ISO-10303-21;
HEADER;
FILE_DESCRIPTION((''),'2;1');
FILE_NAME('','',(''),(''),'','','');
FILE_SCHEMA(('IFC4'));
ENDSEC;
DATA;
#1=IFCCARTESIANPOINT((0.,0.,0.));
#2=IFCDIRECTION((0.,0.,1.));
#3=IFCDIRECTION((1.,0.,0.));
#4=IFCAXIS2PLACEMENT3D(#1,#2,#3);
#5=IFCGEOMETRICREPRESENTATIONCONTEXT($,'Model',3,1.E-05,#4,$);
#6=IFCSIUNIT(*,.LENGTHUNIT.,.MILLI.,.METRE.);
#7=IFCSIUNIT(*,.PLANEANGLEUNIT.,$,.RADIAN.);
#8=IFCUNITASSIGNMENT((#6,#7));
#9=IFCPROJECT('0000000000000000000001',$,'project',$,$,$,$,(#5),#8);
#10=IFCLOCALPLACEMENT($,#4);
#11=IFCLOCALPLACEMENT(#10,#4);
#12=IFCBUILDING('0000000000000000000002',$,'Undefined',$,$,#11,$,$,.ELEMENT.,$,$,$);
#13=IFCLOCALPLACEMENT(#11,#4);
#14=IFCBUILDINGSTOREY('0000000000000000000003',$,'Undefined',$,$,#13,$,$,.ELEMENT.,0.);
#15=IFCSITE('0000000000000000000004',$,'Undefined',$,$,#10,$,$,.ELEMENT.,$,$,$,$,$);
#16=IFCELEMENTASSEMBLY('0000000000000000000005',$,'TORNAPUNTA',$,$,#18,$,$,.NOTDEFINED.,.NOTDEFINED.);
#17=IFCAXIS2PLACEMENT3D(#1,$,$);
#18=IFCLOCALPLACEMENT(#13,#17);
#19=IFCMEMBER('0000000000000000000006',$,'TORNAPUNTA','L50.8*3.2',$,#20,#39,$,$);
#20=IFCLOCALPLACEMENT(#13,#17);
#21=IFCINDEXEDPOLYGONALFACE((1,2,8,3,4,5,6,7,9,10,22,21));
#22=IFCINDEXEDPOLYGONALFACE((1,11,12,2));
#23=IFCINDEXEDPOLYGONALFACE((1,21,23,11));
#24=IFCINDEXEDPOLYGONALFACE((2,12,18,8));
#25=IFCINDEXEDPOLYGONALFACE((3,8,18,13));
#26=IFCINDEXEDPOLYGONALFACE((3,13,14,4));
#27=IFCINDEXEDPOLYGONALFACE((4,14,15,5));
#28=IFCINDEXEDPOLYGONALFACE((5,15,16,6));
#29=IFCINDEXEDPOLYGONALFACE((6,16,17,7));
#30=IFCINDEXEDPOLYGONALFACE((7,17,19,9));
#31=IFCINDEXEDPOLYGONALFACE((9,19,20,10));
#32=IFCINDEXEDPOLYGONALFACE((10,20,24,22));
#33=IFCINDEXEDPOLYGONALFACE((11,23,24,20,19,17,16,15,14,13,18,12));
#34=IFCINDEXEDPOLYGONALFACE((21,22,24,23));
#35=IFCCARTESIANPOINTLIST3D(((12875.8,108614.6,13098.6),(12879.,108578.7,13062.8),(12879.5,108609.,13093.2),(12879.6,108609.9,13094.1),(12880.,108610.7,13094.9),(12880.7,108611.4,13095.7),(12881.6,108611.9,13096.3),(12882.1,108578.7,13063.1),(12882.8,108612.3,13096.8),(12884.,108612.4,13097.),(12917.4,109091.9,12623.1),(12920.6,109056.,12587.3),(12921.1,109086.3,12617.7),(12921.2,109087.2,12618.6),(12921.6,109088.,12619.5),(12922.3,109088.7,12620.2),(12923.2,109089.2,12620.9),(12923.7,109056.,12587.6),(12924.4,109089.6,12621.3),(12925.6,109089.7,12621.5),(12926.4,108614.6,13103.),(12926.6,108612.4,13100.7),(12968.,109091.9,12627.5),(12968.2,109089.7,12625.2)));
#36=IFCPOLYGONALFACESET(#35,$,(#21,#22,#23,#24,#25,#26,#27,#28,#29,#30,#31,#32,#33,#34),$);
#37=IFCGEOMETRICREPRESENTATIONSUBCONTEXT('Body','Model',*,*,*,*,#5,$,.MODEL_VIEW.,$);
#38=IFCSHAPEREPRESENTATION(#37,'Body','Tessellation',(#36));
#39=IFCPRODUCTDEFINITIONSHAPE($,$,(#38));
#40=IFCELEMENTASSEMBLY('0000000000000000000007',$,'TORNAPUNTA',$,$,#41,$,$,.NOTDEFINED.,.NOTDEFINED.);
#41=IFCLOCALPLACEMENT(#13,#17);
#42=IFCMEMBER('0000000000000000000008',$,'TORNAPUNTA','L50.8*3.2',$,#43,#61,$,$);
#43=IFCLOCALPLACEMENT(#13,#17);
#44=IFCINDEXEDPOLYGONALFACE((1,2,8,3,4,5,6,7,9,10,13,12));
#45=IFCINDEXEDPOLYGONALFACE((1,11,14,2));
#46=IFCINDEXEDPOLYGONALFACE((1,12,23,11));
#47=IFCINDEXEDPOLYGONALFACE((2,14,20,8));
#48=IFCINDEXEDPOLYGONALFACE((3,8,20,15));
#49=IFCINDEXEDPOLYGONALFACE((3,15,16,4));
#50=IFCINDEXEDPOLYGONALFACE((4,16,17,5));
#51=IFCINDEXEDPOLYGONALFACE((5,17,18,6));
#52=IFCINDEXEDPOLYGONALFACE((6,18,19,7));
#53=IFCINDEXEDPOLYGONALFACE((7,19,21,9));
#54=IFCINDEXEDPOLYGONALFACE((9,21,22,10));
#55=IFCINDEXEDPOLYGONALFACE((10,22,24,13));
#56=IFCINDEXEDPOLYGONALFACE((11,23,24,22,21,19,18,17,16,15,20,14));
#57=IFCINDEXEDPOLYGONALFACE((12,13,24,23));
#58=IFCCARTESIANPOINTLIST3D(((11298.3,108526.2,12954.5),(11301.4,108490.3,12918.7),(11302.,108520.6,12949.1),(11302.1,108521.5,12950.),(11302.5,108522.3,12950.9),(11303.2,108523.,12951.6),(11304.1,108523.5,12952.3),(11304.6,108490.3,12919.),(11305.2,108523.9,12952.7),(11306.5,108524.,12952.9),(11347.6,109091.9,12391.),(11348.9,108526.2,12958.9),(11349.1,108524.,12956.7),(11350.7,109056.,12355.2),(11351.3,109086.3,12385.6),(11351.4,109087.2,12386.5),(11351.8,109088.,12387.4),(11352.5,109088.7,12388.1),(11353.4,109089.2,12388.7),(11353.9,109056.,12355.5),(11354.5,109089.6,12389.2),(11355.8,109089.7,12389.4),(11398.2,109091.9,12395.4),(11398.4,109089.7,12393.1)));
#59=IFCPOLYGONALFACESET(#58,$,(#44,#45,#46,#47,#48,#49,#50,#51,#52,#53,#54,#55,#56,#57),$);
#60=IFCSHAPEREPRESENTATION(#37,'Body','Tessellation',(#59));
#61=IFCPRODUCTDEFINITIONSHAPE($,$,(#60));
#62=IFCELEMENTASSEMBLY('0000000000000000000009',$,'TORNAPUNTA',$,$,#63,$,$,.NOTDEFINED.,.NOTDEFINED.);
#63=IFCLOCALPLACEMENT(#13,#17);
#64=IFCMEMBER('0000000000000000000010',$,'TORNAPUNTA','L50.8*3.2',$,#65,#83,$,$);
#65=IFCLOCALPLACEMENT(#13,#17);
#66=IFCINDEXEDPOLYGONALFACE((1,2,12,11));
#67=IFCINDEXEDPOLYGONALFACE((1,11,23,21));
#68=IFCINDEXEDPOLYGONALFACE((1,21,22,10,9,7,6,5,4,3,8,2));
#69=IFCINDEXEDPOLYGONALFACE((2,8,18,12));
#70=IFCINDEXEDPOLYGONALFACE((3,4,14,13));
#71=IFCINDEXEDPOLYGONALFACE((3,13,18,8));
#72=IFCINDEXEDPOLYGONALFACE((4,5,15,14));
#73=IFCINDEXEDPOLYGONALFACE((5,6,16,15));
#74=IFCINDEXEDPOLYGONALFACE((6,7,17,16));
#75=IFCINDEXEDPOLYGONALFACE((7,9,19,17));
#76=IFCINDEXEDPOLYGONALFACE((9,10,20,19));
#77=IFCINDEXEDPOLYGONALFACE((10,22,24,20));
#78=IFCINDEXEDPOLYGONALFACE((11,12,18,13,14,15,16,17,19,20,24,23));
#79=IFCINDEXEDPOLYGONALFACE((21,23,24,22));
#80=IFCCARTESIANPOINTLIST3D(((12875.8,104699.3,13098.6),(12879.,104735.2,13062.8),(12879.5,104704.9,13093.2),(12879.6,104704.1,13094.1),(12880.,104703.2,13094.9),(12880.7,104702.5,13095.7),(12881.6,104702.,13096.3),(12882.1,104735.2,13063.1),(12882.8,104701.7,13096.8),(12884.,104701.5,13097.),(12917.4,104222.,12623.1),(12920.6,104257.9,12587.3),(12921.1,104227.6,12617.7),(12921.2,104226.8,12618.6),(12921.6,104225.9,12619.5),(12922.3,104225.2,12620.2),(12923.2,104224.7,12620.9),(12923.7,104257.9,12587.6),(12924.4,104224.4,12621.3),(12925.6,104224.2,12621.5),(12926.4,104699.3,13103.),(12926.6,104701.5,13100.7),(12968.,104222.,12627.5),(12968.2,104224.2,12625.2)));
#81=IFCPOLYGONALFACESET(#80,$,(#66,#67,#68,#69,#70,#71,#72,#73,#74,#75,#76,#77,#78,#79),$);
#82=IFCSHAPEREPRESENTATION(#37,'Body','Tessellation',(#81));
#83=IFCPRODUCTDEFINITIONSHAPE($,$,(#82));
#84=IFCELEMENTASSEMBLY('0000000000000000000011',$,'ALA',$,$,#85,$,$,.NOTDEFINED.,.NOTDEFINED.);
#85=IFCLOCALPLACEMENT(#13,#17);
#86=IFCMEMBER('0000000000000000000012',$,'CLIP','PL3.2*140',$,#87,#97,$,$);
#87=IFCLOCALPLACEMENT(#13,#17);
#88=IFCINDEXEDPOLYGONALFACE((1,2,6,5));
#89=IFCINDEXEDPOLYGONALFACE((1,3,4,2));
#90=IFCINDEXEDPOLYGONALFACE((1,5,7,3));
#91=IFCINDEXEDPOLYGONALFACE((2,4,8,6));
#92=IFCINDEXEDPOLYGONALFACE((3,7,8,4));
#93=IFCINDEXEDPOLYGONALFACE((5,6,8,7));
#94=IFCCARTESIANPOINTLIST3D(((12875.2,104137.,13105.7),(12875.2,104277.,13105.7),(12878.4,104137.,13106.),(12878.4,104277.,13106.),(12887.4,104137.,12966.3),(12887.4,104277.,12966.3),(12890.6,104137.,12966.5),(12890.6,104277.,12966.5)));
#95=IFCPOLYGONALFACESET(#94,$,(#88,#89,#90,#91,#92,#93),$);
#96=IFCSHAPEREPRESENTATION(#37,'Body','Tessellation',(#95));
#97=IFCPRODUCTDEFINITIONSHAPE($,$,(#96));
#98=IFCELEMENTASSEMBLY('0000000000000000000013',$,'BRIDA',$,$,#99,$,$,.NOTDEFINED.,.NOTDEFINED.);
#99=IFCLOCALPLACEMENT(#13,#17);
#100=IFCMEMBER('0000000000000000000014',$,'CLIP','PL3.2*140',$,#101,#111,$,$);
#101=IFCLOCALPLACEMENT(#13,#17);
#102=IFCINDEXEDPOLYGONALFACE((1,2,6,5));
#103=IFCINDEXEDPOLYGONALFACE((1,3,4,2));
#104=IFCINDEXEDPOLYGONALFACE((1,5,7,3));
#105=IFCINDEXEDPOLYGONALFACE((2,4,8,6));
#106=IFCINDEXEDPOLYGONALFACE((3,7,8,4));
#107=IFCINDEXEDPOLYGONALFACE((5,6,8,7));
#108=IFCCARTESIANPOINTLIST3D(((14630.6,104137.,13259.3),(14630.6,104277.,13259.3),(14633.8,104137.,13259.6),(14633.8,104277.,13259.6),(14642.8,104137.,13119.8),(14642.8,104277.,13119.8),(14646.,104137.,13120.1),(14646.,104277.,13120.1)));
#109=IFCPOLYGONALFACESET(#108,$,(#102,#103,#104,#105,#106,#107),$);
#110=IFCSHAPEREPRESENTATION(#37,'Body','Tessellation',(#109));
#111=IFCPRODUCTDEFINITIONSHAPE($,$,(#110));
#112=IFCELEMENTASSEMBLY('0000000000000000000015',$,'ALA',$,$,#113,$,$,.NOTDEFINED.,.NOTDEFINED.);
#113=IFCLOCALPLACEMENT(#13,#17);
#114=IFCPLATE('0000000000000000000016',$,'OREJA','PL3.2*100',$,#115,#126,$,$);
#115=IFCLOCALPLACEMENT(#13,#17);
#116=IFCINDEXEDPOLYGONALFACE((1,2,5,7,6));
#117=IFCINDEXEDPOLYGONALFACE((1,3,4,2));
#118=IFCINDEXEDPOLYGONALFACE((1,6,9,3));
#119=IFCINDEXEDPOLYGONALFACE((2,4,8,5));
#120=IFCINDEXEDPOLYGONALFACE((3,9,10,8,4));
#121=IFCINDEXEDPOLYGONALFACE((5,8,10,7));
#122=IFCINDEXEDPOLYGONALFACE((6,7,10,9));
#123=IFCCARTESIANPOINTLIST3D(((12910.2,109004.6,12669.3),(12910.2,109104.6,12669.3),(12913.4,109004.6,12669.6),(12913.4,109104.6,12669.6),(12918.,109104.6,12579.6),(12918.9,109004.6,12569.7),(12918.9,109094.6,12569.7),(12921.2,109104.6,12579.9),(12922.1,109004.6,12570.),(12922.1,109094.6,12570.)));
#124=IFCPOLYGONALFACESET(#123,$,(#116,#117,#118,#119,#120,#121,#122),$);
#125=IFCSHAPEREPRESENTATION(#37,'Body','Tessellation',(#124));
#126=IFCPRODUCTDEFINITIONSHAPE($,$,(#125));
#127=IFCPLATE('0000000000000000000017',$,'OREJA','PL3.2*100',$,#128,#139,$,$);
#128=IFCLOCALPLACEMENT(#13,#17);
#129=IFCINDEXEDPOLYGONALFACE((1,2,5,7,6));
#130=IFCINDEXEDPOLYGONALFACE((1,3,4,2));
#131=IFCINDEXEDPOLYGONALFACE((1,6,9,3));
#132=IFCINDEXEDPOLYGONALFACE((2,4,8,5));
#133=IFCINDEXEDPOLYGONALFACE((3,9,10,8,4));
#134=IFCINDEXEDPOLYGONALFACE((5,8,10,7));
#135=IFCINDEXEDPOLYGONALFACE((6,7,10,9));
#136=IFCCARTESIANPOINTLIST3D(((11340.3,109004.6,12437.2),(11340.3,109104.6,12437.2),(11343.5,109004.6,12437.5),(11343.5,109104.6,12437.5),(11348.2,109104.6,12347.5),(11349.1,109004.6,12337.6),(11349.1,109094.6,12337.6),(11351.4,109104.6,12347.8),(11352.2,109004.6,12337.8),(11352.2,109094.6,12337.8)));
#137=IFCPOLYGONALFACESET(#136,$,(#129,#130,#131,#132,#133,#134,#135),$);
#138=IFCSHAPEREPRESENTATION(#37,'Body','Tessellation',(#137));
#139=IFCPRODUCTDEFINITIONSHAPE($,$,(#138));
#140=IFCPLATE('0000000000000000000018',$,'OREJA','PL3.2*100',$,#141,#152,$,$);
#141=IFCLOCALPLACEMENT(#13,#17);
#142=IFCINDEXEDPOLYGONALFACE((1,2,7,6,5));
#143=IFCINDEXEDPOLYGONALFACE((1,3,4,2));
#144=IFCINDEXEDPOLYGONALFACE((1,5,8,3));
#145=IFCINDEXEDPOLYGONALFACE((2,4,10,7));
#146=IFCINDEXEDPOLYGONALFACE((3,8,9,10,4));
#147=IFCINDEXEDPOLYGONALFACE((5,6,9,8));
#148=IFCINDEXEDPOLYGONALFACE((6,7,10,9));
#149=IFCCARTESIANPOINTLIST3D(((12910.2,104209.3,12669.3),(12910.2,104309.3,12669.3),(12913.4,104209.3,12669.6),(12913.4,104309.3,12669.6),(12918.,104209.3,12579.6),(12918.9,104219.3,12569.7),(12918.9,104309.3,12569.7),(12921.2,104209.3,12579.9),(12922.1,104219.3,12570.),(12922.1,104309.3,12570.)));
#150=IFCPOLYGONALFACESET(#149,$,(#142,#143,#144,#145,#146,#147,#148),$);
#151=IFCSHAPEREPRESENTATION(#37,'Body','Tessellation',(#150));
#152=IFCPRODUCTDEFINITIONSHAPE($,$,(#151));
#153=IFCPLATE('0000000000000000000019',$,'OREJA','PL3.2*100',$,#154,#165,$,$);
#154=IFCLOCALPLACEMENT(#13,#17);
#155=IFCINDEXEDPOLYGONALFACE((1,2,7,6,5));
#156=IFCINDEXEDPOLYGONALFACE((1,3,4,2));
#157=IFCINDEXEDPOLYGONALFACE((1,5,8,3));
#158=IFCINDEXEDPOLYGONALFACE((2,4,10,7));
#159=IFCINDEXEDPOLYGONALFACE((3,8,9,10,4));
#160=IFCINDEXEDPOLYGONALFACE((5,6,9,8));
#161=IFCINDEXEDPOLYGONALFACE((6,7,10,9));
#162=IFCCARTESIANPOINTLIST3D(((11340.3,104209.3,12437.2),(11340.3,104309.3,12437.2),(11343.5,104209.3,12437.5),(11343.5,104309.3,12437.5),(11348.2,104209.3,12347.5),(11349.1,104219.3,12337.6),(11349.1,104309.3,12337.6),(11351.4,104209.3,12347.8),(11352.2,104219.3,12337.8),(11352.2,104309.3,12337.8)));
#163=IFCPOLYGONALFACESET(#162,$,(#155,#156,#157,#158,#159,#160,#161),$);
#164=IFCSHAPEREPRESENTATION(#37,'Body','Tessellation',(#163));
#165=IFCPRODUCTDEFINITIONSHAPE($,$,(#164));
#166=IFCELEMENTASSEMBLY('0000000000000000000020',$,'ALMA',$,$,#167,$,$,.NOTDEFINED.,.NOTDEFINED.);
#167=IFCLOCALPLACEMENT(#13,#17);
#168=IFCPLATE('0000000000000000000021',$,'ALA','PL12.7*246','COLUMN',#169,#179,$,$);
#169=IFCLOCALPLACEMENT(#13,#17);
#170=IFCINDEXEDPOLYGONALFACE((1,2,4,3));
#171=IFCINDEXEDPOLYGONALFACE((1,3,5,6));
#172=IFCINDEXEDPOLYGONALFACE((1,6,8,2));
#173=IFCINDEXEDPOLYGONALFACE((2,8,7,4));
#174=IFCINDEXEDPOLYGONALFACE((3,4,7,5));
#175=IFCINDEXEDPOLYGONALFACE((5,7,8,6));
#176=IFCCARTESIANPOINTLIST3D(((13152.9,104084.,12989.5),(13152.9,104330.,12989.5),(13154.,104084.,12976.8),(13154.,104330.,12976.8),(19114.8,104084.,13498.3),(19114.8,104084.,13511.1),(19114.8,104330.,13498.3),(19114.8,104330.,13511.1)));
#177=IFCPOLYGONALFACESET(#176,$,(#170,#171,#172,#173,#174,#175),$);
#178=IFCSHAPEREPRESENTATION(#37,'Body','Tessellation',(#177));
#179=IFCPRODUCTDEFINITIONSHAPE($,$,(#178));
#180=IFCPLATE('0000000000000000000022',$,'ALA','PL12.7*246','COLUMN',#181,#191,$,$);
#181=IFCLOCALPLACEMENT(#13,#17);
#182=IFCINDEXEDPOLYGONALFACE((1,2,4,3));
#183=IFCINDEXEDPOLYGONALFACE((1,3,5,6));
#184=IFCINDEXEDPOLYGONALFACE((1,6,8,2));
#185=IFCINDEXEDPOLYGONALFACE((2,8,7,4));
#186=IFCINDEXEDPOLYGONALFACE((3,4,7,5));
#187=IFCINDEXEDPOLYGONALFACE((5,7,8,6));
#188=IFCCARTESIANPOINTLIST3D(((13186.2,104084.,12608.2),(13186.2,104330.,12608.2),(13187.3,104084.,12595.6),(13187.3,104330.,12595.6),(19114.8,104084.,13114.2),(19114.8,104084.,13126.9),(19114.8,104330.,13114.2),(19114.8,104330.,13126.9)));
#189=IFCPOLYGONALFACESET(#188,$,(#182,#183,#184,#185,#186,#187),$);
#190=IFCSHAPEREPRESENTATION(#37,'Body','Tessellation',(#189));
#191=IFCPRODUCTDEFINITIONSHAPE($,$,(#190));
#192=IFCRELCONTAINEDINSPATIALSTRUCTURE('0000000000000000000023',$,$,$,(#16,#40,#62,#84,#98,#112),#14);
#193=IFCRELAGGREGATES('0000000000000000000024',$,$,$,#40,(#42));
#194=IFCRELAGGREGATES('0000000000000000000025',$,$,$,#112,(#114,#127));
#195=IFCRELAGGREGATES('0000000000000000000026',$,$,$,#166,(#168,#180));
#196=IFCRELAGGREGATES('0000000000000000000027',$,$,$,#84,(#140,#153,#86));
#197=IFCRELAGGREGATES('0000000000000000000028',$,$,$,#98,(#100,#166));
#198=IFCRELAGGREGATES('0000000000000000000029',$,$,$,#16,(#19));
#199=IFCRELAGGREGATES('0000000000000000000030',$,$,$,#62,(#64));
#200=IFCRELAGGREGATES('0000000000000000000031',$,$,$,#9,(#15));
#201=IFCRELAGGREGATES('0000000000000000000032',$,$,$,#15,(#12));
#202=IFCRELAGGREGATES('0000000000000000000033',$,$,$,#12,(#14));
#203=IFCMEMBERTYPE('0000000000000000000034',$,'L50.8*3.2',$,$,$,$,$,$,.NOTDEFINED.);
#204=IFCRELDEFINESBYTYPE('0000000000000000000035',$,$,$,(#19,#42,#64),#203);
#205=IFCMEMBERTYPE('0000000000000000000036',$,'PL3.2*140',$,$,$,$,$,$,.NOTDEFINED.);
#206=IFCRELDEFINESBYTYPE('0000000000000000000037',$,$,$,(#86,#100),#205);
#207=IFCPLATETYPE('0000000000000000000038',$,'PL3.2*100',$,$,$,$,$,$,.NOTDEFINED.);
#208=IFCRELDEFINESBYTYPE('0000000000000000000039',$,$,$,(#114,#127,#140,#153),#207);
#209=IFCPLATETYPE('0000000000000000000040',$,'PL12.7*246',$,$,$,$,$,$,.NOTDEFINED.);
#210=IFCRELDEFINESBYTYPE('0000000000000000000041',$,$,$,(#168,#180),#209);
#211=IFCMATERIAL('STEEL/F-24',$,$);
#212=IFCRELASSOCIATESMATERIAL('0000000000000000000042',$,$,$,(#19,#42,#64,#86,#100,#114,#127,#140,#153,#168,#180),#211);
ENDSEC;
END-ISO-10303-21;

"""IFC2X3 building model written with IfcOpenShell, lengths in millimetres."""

from ifc_helpers import new_model, si_unit, frame, origin_with_axes, origin_2d_with_axis, place, context, subcontext, project, spatial, polyline, rectangle, l_section, outline, extrude, clip, halfspace, material, type_object, element, aggregate, save


model = new_model("IFC2X3")

# Units and contexts
model_context = context("Model", 3, precision=1e-05, world=origin_with_axes())
body_context = subcontext(model_context, "Body", "Model", "MODEL_VIEW")
ifc_project = project(units=[si_unit("LENGTHUNIT", "METRE", prefix="MILLI"), si_unit("PLANEANGLEUNIT", "RADIAN")], contexts=[model_context])

# Site, building, storey
site_placement = place(None, origin_with_axes())
site = spatial("IfcSite", under=ifc_project, at=site_placement, Name="Undefined", CompositionType="ELEMENT")
building_placement = place(site_placement, origin_with_axes())
building = spatial("IfcBuilding", under=site, at=building_placement, Name="Undefined", CompositionType="ELEMENT")
storey_placement = place(building_placement, origin_with_axes())
storey = spatial("IfcBuildingStorey", under=building, at=storey_placement, Name="Undefined", CompositionType="ELEMENT", Elevation=0.0)

# Element assemblies, members
assembly_1_placement = place(storey_placement, origin_with_axes())
assembly_1 = element("IfcElementAssembly", 1, at=assembly_1_placement, inside=storey, Name="TORNAPUNTA", AssemblyPlace="NOTDEFINED", PredefinedType="NOTDEFINED")
ifc_material_1 = material(Name="STEEL/F-24")
member_type_1 = type_object("IfcMemberType", Name="L50.8*3.2", PredefinedType="NOTDEFINED")
member_1_placement = place(assembly_1_placement, frame((12944.3, 109074.0, 12607.4), z_axis=(0.061628, -0.707107, -0.704416), x_axis=(-0.061628, -0.707107, 0.704416)))
member_1 = element("IfcMember", 2, at=member_1_placement, type_object=member_type_1, material=ifc_material_1, Name="TORNAPUNTA", Description="L50.8*3.2", context=body_context, shape_type="SweptSolid", body=[
    extrude(l_section(Depth=50.8, Width=50.8, Thickness=3.2, FilletRadius=4.8, at=origin_2d_with_axis()), frame((675.0, 0.0, 0.0), z_axis=(-1.0, 0.0, 0.0), x_axis=(0.0, -1.0, 0.0)), (0.0, 0.0, 1.0), 675.0),
])
assembly_2_placement = place(storey_placement, origin_with_axes())
assembly_2 = element("IfcElementAssembly", 3, at=assembly_2_placement, inside=storey, Name="TORNAPUNTA", AssemblyPlace="NOTDEFINED", PredefinedType="NOTDEFINED")
member_2_placement = place(assembly_2_placement, frame((11374.5, 109074.0, 12375.3), z_axis=(0.061628, -0.707107, -0.704416), x_axis=(-0.061628, -0.707107, 0.704416)))
member_2 = element("IfcMember", 4, at=member_2_placement, type_object=member_type_1, material=ifc_material_1, Name="TORNAPUNTA", Description="L50.8*3.2", context=body_context, shape_type="SweptSolid", body=[
    extrude(l_section(Depth=50.8, Width=50.8, Thickness=3.2, FilletRadius=4.8, at=origin_2d_with_axis()), frame((800.0, 0.0, 0.0), z_axis=(-1.0, 0.0, 0.0), x_axis=(0.0, -1.0, 0.0)), (0.0, 0.0, 1.0), 800.0),
])
aggregate(assembly_2, [member_2])
assembly_3_placement = place(storey_placement, origin_with_axes())
assembly_3 = element("IfcElementAssembly", 5, at=assembly_3_placement, inside=storey, Name="TORNAPUNTA", AssemblyPlace="NOTDEFINED", PredefinedType="NOTDEFINED")
member_3_placement = place(assembly_3_placement, frame((12902.7, 104717.2, 13082.9), z_axis=(0.061628, 0.707107, -0.704416), x_axis=(0.061628, -0.707107, -0.704416)))
member_3 = element("IfcMember", 6, at=member_3_placement, type_object=member_type_1, material=ifc_material_1, Name="TORNAPUNTA", Description="L50.8*3.2", context=body_context, shape_type="SweptSolid", body=[
    extrude(l_section(Depth=50.8, Width=50.8, Thickness=3.2, FilletRadius=4.8, at=origin_2d_with_axis()), frame((675.0, 0.0, 0.0), z_axis=(-1.0, 0.0, 0.0), x_axis=(0.0, -1.0, 0.0)), (0.0, 0.0, 1.0), 675.0),
])
assembly_4_placement = place(storey_placement, origin_with_axes())
assembly_4 = element("IfcElementAssembly", 7, at=assembly_4_placement, inside=storey, Name="ALA", AssemblyPlace="NOTDEFINED", PredefinedType="NOTDEFINED")
member_type_2 = type_object("IfcMemberType", Name="PL3.2*140", PredefinedType="NOTDEFINED")
member_4_placement = place(assembly_4_placement, frame((12876.8, 104207.0, 13105.9), z_axis=(0.0, -1.0, 0.0), x_axis=(0.087155, 0.0, -0.996195)))
member_4 = element("IfcMember", 8, at=member_4_placement, type_object=member_type_2, material=ifc_material_1, Name="CLIP", Description="PL3.2*140", context=body_context, shape_type="SweptSolid", body=[
    extrude(rectangle(XDim=3.2, YDim=140.0, at=origin_2d_with_axis()), frame((140.0, 0.0, 0.0), z_axis=(-1.0, 0.0, 0.0), x_axis=(0.0, -1.0, 0.0)), (0.0, 0.0, 1.0), 140.0),
])
assembly_5_placement = place(storey_placement, origin_with_axes())
assembly_5 = element("IfcElementAssembly", 9, at=assembly_5_placement, inside=storey, Name="BRIDA", AssemblyPlace="NOTDEFINED", PredefinedType="NOTDEFINED")
member_5_placement = place(assembly_5_placement, frame((14632.2, 104207.0, 13259.5), z_axis=(0.0, -1.0, 0.0), x_axis=(0.087155, 0.0, -0.996195)))
member_5 = element("IfcMember", 10, at=member_5_placement, type_object=member_type_2, material=ifc_material_1, Name="CLIP", Description="PL3.2*140", context=body_context, shape_type="SweptSolid", body=[
    extrude(rectangle(XDim=3.2, YDim=140.0, at=origin_2d_with_axis()), frame((140.0, 0.0, 0.0), z_axis=(-1.0, 0.0, 0.0), x_axis=(0.0, -1.0, 0.0)), (0.0, 0.0, 1.0), 140.0),
])

# Element assembly, plates
assembly_6_placement = place(storey_placement, origin_with_axes())
assembly_6 = element("IfcElementAssembly", 11, at=assembly_6_placement, inside=storey, Name="ALA", AssemblyPlace="NOTDEFINED", PredefinedType="NOTDEFINED")
plate_type_1 = type_object("IfcPlateType", Name="PL3.2*100", PredefinedType="NOTDEFINED")
plate_1_placement = place(assembly_6_placement, frame((12920.5, 109004.6, 12569.8), z_axis=(0.996195, 0.0, 0.087155), x_axis=(0.0, 1.0, 0.0)))
plate_1 = element("IfcPlate", 12, at=plate_1_placement, type_object=plate_type_1, material=ifc_material_1, Name="OREJA", Description="PL3.2*100", context=body_context, shape_type="SweptSolid", body=[
    extrude(outline(polyline([(0.0, 0.0), (90.0, 0.0), (100.0, 10.0), (100.0, 100.0), (0.0, 100.0), (0.0, 0.0)])), frame((0.0, 0.0, -1.6), z_axis=(0.0, 0.0, 1.0), x_axis=(1.0, 0.0, 0.0)), (0.0, 0.0, 1.0), 3.2),
])
plate_2_placement = place(assembly_6_placement, frame((11350.6, 109004.6, 12337.7), z_axis=(0.996195, 0.0, 0.087155), x_axis=(0.0, 1.0, 0.0)))
plate_2 = element("IfcPlate", 13, at=plate_2_placement, type_object=plate_type_1, material=ifc_material_1, Name="OREJA", Description="PL3.2*100", context=body_context, shape_type="SweptSolid", body=[
    extrude(outline(polyline([(0.0, 0.0), (90.0, 0.0), (100.0, 10.0), (100.0, 100.0), (0.0, 100.0), (0.0, 0.0)])), frame((0.0, 0.0, -1.6), z_axis=(0.0, 0.0, 1.0), x_axis=(1.0, 0.0, 0.0)), (0.0, 0.0, 1.0), 3.2),
])
aggregate(assembly_6, [plate_1, plate_2])

# Plates
plate_3_placement = place(assembly_4_placement, frame((12920.5, 104309.3, 12569.8), z_axis=(-0.996195, 0.0, -0.087155), x_axis=(0.0, -1.0, 0.0)))
plate_3 = element("IfcPlate", 14, at=plate_3_placement, type_object=plate_type_1, material=ifc_material_1, Name="OREJA", Description="PL3.2*100", context=body_context, shape_type="SweptSolid", body=[
    extrude(outline(polyline([(0.0, 0.0), (90.0, 0.0), (100.0, 10.0), (100.0, 100.0), (0.0, 100.0), (0.0, 0.0)])), frame((0.0, 0.0, -1.6), z_axis=(0.0, 0.0, 1.0), x_axis=(1.0, 0.0, 0.0)), (0.0, 0.0, 1.0), 3.2),
])
plate_4_placement = place(assembly_4_placement, frame((11350.6, 104309.3, 12337.7), z_axis=(-0.996195, 0.0, -0.087155), x_axis=(0.0, -1.0, 0.0)))
plate_4 = element("IfcPlate", 15, at=plate_4_placement, type_object=plate_type_1, material=ifc_material_1, Name="OREJA", Description="PL3.2*100", context=body_context, shape_type="SweptSolid", body=[
    extrude(outline(polyline([(0.0, 0.0), (90.0, 0.0), (100.0, 10.0), (100.0, 100.0), (0.0, 100.0), (0.0, 0.0)])), frame((0.0, 0.0, -1.6), z_axis=(0.0, 0.0, 1.0), x_axis=(1.0, 0.0, 0.0)), (0.0, 0.0, 1.0), 3.2),
])

# Shared definitions
plate_type_2 = type_object("IfcPlateType", Name="PL12.7*246", PredefinedType="NOTDEFINED")

# Element assembly, plates
assembly_7_placement = place(assembly_5_placement, origin_with_axes())
assembly_7 = element("IfcElementAssembly", 16, at=assembly_7_placement, Name="ALMA", AssemblyPlace="NOTDEFINED", PredefinedType="NOTDEFINED")
plate_5_placement = place(assembly_7_placement, frame((13153.4, 104207.0, 12983.2), z_axis=(0.087155, 0.0, -0.996195), x_axis=(0.996195, 0.0, 0.087155)))
plate_5 = element("IfcPlate", 17, at=plate_5_placement, type_object=plate_type_2, material=ifc_material_1, Name="ALA", Description="PL12.7*246", ObjectType="COLUMN", context=body_context, shape_type="Clipping", body=[
    clip(clip(extrude(outline(polyline([(0.1, -123.0), (0.1, 123.0), (5984.8, 123.0), (5984.8, -123.0), (0.1, -123.0)])), frame((0.0, 0.0, -6.3), z_axis=(0.0, 0.0, 1.0), x_axis=(1.0, 0.0, 0.0)), (0.0, 0.0, 1.0), 12.7), halfspace(frame((5984.8, 0.0, -6.4), z_axis=(-0.996195, 0.0, -0.087155), x_axis=(0.0, 1.0, 0.0)), True)), halfspace(frame((0.1, 0.0, 0.0), z_axis=(-1.0, 0.0, 0.0), x_axis=(0.0, 1.0, 0.0)), False)),
])
plate_6_placement = place(assembly_7_placement, frame((13186.7, 104207.0, 12601.9), z_axis=(0.087155, 0.0, -0.996195), x_axis=(0.996195, 0.0, 0.087155)))
plate_6 = element("IfcPlate", 18, at=plate_6_placement, type_object=plate_type_2, material=ifc_material_1, Name="ALA", Description="PL12.7*246", ObjectType="COLUMN", context=body_context, shape_type="Clipping", body=[
    clip(clip(extrude(outline(polyline([(0.1, -123.0), (0.1, 123.0), (5951.3, 123.0), (5951.3, -123.0), (0.1, -123.0)])), frame((0.0, 0.0, -6.3), z_axis=(0.0, 0.0, 1.0), x_axis=(1.0, 0.0, 0.0)), (0.0, 0.0, 1.0), 12.7), halfspace(frame((5951.3, 0.0, -6.4), z_axis=(-0.996195, 0.0, -0.087155), x_axis=(0.0, 1.0, 0.0)), True)), halfspace(frame((0.1, 0.0, 0.0), z_axis=(1.0, 0.0, 0.0), x_axis=(0.0, -1.0, 0.0)), True)),
])
aggregate(assembly_7, [plate_5, plate_6])

aggregate(assembly_4, [plate_3, plate_4, member_4])
aggregate(assembly_5, [member_5, assembly_7])

aggregate(assembly_1, [member_1])
aggregate(assembly_3, [member_3])

save(model, "model.ifc")
